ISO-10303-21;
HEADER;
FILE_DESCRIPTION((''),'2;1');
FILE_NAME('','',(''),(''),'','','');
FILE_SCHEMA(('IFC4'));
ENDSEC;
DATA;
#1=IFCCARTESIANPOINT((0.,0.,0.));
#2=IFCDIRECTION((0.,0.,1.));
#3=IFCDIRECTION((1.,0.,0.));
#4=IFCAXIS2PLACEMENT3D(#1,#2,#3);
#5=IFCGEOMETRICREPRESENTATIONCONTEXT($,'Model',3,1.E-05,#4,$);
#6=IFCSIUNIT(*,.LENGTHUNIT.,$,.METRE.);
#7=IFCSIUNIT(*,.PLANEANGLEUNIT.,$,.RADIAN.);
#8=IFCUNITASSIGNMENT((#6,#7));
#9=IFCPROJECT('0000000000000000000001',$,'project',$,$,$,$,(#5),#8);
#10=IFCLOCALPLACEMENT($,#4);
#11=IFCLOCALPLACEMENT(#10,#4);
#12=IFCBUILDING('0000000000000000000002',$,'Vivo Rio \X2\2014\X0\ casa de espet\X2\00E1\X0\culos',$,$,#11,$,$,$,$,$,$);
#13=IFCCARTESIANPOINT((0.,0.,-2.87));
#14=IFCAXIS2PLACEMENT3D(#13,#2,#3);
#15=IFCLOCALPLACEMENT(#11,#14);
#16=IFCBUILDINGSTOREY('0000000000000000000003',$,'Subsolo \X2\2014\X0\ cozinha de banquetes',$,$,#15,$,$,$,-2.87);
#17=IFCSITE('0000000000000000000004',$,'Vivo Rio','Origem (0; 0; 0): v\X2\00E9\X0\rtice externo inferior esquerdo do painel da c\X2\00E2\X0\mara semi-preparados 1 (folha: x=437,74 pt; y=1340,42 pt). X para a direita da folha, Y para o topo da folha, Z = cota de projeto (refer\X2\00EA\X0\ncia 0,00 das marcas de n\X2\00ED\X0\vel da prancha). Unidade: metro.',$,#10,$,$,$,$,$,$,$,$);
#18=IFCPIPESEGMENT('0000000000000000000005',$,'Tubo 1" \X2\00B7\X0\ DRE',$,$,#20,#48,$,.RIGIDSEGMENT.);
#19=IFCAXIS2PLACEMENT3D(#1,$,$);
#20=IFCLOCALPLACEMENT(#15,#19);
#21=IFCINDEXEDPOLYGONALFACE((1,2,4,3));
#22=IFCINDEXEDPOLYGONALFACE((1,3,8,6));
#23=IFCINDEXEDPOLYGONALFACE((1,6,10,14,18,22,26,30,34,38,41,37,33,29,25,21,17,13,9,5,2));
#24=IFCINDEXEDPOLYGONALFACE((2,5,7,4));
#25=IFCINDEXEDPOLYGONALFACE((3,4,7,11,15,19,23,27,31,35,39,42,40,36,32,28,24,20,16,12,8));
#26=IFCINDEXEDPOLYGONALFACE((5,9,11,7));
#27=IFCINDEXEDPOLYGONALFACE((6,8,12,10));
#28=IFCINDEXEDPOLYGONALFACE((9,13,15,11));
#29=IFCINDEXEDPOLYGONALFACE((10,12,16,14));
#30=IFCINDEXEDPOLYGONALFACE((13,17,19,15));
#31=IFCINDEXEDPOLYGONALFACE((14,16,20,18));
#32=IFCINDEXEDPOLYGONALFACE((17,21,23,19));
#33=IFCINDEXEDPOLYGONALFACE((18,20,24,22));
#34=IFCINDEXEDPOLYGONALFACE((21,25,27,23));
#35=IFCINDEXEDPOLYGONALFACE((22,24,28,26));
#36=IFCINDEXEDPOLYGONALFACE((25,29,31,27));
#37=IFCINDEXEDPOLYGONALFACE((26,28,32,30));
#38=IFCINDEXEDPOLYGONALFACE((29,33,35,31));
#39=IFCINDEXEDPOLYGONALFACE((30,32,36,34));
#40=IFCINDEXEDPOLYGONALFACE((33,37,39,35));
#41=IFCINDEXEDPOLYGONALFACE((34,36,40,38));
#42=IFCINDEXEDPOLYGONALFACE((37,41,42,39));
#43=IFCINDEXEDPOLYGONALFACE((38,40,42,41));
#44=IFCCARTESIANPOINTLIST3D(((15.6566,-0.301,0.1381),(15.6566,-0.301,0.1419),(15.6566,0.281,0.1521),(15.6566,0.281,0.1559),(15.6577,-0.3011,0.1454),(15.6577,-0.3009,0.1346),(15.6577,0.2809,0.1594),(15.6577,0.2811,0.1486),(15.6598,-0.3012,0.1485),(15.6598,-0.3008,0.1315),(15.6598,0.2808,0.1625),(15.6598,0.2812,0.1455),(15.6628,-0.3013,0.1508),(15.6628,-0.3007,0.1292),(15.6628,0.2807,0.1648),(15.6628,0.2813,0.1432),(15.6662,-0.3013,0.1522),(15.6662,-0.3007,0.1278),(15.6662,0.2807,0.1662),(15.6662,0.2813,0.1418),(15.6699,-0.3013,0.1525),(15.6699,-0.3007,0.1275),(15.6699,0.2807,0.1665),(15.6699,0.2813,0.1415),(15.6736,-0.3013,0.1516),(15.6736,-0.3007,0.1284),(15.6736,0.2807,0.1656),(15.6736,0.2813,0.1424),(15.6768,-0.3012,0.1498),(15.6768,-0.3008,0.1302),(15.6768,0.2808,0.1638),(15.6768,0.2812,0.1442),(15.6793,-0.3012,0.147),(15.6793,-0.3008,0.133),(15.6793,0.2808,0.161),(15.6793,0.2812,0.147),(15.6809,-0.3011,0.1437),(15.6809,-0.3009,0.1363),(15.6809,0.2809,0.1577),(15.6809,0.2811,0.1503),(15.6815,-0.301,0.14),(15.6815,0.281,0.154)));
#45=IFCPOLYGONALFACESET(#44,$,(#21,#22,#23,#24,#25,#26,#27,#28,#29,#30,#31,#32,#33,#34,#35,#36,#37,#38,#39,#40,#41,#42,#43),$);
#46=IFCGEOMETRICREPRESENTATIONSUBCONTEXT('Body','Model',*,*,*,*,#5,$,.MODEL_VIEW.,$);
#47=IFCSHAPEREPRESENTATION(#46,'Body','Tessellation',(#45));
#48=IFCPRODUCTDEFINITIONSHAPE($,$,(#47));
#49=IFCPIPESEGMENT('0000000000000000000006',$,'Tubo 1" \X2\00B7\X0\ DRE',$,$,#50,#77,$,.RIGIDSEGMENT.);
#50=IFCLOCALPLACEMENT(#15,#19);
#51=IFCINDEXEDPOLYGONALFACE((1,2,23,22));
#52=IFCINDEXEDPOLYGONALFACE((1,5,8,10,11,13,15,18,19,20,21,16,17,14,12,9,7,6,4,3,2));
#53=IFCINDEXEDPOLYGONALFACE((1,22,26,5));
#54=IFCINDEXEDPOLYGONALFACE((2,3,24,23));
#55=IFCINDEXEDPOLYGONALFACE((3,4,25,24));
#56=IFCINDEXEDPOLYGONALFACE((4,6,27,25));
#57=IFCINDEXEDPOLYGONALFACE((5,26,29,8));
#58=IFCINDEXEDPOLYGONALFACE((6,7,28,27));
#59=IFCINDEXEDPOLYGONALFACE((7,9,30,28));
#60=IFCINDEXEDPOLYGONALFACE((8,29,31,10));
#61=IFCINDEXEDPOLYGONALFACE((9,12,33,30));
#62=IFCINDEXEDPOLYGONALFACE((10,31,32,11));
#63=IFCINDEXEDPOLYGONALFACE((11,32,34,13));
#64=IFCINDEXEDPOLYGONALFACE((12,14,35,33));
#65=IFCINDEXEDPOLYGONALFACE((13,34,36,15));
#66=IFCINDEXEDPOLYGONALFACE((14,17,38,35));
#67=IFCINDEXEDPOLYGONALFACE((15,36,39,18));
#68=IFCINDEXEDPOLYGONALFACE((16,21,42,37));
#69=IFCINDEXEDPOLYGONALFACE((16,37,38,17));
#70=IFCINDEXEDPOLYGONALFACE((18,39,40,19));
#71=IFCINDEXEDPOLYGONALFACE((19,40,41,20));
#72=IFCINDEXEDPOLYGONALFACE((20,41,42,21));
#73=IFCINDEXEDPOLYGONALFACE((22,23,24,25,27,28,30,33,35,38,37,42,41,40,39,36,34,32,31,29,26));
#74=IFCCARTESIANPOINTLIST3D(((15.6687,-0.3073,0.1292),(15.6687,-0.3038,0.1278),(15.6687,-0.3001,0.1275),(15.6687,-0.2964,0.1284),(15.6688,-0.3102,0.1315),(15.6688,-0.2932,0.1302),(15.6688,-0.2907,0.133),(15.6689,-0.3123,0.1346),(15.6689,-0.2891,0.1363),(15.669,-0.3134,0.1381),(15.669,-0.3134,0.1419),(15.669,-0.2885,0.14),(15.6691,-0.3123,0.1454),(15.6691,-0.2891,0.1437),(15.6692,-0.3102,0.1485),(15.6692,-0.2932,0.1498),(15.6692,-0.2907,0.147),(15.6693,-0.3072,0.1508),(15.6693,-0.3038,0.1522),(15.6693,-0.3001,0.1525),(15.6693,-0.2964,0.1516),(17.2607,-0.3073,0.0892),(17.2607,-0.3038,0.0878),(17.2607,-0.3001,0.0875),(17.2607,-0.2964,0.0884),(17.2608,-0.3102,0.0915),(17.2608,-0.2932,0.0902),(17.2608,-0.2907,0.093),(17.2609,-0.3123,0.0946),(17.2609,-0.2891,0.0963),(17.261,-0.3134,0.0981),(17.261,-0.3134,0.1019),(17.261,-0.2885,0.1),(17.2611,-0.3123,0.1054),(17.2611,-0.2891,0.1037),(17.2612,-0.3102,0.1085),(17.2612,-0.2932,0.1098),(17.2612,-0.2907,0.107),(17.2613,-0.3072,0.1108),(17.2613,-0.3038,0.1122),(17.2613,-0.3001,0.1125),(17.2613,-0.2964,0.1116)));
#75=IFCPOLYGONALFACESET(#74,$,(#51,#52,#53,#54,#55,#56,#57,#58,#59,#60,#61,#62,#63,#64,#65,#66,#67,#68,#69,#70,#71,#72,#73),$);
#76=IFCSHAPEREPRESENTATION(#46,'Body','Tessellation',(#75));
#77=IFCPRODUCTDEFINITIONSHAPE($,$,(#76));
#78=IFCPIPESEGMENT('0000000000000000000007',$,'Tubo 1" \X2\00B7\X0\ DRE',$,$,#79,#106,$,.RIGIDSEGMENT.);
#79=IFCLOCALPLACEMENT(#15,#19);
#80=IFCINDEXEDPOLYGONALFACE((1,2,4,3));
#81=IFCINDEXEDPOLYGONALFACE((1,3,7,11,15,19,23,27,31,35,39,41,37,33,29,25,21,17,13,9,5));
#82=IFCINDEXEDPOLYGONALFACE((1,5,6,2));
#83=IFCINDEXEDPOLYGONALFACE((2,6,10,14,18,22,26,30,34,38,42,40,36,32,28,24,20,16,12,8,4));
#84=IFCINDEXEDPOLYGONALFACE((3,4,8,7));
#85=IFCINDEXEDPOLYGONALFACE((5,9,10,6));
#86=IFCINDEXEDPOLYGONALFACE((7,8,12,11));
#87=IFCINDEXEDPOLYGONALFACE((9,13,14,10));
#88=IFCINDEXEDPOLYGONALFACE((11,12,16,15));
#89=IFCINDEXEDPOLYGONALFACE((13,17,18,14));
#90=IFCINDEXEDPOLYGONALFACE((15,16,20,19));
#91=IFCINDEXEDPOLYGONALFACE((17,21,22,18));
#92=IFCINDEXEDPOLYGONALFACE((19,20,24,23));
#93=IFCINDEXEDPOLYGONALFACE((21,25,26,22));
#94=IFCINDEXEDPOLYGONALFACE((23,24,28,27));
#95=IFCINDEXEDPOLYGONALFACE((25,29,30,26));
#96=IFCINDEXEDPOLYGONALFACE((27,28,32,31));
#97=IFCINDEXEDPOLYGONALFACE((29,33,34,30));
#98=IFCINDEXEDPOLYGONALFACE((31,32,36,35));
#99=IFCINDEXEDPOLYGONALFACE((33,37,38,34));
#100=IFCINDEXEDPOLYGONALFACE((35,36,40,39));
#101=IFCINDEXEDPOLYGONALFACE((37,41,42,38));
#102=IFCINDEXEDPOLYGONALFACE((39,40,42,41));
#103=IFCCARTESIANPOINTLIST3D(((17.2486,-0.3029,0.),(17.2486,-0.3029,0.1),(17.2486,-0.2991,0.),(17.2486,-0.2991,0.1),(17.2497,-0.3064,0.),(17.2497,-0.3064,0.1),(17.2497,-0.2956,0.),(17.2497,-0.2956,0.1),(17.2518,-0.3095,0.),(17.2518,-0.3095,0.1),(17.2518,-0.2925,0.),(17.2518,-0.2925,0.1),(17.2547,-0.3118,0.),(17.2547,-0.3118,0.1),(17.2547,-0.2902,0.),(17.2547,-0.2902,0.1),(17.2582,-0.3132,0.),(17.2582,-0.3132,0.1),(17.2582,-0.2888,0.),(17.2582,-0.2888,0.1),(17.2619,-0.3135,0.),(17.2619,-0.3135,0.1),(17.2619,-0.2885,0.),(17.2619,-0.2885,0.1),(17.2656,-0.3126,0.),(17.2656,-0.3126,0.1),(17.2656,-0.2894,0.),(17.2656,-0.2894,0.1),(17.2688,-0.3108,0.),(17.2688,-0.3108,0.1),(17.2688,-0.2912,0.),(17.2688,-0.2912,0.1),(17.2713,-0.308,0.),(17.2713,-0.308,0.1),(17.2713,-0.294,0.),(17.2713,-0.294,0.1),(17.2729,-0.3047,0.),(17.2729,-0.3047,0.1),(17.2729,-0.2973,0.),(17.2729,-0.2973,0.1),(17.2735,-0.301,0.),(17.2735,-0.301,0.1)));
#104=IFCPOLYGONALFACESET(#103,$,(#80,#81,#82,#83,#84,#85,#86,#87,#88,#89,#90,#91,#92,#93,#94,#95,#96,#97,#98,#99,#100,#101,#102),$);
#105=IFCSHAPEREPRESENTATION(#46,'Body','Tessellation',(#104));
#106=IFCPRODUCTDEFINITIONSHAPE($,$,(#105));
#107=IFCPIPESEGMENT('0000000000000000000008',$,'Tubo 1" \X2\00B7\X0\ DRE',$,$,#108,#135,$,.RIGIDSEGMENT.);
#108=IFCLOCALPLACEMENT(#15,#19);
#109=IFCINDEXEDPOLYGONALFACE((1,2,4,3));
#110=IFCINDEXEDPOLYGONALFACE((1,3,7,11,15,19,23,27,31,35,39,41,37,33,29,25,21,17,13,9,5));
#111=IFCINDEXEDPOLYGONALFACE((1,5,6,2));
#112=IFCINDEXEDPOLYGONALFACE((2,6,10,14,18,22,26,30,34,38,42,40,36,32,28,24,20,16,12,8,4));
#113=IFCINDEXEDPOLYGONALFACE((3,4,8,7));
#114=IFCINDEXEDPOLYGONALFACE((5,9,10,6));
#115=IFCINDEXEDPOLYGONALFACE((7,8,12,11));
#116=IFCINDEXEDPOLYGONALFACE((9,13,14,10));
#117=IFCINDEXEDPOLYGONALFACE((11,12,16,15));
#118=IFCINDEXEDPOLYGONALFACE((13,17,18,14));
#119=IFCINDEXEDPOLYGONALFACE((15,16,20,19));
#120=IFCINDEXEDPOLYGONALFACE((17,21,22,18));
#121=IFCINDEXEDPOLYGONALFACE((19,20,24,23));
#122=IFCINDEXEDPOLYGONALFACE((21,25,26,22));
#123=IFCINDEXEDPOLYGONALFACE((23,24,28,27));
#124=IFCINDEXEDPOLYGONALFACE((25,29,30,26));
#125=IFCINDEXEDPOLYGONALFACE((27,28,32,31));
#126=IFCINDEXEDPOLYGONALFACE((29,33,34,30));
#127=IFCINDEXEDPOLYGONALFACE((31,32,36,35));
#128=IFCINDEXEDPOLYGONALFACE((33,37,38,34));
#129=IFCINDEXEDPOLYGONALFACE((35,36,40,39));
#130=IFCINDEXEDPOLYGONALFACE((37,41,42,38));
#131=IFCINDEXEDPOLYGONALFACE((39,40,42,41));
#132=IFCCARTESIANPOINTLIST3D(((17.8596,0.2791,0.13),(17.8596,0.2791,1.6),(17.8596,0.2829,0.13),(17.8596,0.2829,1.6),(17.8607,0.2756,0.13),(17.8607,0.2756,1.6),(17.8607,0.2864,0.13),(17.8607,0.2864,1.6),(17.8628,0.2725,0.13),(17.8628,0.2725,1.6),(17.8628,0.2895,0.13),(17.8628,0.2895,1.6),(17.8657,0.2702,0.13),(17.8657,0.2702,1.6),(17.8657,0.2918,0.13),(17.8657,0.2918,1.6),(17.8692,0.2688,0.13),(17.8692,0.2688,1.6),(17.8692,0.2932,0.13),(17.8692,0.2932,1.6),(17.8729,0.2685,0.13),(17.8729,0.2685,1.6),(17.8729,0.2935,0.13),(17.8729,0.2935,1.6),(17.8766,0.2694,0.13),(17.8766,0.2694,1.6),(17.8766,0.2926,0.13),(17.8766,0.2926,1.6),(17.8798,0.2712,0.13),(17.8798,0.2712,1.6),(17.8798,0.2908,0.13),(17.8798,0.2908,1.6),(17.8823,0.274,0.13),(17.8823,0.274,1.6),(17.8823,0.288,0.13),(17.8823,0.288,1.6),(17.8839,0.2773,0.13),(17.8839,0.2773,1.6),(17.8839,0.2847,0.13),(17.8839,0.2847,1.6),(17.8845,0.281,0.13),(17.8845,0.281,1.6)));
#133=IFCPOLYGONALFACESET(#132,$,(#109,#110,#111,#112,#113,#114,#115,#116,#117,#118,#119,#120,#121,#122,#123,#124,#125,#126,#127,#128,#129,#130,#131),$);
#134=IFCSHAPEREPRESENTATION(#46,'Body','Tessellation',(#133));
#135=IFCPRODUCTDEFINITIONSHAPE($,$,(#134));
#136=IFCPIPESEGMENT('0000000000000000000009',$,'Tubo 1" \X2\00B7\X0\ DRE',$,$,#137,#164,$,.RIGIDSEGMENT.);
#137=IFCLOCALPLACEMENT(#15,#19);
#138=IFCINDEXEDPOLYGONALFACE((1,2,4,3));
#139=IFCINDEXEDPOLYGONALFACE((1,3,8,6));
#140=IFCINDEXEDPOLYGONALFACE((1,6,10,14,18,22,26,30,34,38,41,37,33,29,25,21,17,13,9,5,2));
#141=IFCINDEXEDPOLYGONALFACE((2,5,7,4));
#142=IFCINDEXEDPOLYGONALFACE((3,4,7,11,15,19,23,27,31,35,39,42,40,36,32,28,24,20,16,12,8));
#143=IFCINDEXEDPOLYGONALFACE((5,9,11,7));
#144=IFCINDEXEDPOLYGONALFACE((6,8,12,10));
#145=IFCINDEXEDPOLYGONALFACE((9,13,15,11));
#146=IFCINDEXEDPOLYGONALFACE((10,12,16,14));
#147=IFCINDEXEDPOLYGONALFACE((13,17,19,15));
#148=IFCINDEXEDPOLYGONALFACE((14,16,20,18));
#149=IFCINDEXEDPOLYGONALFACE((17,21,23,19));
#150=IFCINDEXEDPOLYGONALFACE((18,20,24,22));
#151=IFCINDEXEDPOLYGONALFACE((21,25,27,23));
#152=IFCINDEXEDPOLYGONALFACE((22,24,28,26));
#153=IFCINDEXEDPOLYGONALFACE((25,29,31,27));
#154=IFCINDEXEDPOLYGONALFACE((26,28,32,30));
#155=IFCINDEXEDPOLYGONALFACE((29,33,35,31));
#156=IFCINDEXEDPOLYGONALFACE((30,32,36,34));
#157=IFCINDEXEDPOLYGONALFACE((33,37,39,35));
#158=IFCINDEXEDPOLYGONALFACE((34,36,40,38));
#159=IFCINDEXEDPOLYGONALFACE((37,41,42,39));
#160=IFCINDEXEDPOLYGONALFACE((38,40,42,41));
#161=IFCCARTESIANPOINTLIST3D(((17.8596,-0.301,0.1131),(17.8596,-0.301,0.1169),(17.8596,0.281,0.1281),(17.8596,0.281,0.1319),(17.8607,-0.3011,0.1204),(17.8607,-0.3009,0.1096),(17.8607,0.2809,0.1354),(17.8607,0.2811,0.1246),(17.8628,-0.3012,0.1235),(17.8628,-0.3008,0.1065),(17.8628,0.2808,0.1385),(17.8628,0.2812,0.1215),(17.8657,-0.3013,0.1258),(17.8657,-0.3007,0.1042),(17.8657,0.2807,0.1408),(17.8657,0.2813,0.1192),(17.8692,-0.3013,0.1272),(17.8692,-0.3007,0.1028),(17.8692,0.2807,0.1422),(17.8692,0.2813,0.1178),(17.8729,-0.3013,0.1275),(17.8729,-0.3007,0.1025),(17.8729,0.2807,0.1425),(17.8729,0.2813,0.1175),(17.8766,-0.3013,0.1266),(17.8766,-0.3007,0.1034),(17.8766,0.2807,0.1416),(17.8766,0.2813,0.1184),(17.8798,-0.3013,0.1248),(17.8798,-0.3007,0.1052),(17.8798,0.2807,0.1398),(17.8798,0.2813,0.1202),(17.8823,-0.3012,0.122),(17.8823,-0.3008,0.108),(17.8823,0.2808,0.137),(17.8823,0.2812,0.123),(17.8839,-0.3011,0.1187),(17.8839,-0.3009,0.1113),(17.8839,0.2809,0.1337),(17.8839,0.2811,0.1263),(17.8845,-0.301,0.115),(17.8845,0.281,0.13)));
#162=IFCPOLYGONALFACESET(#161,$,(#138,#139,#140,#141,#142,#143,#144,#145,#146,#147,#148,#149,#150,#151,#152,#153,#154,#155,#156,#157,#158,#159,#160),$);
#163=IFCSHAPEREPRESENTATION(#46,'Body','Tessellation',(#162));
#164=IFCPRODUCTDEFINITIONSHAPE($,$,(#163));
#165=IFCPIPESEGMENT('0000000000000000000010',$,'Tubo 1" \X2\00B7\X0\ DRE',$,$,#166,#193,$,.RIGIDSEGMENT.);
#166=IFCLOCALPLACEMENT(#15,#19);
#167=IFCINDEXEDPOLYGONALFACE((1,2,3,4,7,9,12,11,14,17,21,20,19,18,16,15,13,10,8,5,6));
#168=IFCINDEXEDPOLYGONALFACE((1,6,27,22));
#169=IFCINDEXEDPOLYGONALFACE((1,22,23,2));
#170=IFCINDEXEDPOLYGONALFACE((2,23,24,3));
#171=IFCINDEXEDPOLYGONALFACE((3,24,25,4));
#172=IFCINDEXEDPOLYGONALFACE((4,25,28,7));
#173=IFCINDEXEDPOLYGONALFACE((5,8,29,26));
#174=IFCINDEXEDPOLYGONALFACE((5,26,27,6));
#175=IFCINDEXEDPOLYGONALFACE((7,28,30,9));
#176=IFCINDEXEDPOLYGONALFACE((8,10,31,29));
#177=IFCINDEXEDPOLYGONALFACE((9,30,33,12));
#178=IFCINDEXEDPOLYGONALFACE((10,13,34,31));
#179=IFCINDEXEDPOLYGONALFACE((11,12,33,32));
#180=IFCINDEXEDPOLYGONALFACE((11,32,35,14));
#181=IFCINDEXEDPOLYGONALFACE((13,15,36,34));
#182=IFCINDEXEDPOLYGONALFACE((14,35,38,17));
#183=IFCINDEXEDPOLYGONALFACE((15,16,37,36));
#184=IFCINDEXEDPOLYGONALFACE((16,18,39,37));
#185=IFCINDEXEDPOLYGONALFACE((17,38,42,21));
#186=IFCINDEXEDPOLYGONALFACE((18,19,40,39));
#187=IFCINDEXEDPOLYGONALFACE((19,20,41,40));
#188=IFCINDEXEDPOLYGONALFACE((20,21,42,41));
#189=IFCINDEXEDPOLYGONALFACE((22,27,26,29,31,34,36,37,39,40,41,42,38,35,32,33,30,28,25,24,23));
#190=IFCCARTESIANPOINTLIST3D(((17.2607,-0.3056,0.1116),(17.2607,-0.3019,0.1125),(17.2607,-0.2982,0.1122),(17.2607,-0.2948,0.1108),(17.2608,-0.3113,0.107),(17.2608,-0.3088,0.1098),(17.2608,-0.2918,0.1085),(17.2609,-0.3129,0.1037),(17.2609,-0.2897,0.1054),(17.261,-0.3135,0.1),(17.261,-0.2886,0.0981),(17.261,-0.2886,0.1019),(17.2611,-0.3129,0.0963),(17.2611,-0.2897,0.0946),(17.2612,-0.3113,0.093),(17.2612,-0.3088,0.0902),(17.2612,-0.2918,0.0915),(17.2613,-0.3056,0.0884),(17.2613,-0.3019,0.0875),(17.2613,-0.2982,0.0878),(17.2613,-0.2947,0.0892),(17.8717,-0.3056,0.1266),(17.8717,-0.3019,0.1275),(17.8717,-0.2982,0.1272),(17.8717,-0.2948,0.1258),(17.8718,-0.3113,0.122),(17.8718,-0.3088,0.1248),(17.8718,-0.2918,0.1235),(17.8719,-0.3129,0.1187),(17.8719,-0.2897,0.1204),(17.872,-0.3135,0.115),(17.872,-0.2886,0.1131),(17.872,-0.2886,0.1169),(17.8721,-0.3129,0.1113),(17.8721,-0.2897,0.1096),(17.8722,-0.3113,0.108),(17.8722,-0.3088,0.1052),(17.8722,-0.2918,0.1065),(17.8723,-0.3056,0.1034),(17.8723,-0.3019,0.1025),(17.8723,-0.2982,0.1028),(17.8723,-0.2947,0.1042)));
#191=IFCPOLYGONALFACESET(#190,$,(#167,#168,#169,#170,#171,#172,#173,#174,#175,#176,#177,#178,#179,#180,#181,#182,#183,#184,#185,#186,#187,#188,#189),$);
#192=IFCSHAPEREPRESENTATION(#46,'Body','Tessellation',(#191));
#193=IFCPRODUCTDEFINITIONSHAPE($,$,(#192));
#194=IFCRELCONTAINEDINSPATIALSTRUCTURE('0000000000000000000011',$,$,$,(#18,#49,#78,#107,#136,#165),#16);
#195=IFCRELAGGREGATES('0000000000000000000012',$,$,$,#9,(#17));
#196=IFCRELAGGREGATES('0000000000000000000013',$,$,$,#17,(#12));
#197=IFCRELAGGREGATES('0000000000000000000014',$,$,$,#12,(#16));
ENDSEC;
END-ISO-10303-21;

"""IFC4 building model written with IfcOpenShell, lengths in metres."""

from ifc_helpers import new_model, si_unit, frame, origin_with_axes, origin_2d, place, context, subcontext, project, spatial, circle, extrude, element, save


model = new_model("IFC4")

# Units and contexts
model_context = context("Model", 3, precision=1e-05, world=origin_with_axes())
body_context = subcontext(model_context, "Body", "Model", "MODEL_VIEW")
ifc_project = project(units=[si_unit("LENGTHUNIT", "METRE"), si_unit("PLANEANGLEUNIT", "RADIAN")], contexts=[model_context])

# Site, building, storey
site_placement = place(None, origin_with_axes())
site = spatial("IfcSite", under=ifc_project, at=site_placement, Name="Vivo Rio", Description="Origem (0; 0; 0): vértice externo inferior esquerdo do painel da câmara semi-preparados 1 (folha: x=437,74 pt; y=1340,42 pt). X para a direita da folha, Y para o topo da folha, Z = cota de projeto (referência 0,00 das marcas de nível da prancha). Unidade: metro.")
building_placement = place(site_placement, origin_with_axes())
building = spatial("IfcBuilding", under=site, at=building_placement, Name="Vivo Rio — casa de espetáculos")
storey_placement = place(building_placement, frame((0.0, 0.0, -2.87), z_axis=(0.0, 0.0, 1.0), x_axis=(1.0, 0.0, 0.0)))
storey = spatial("IfcBuildingStorey", under=building, at=storey_placement, Name="Subsolo — cozinha de banquetes", Elevation=-2.87)

# Pipe segments
pipe_segment_1_placement = place(storey_placement, origin_with_axes())
element("IfcPipeSegment", 1, at=pipe_segment_1_placement, inside=storey, Name="Tubo 1\" · DRE", PredefinedType="RIGIDSEGMENT", context=body_context, shape_type="SweptSolid", body=[
    extrude(circle(Radius=0.0125, at=origin_2d()), frame((15.669, 0.281, 0.154), z_axis=(0.0, -0.999711, -0.024048), x_axis=(1.0, 0.0, 0.0)), (0.0, 0.0, 1.0), 0.5822),
])
pipe_segment_2_placement = place(storey_placement, origin_with_axes())
element("IfcPipeSegment", 2, at=pipe_segment_2_placement, inside=storey, Name="Tubo 1\" · DRE", PredefinedType="RIGIDSEGMENT", context=body_context, shape_type="SweptSolid", body=[
    extrude(circle(Radius=0.0125, at=origin_2d()), frame((15.669, -0.301, 0.14), z_axis=(0.999685, 0.0, -0.025118), x_axis=(0.0, 1.0, 0.0)), (0.0, 0.0, 1.0), 1.5925),
])
pipe_segment_3_placement = place(storey_placement, origin_with_axes())
element("IfcPipeSegment", 3, at=pipe_segment_3_placement, inside=storey, Name="Tubo 1\" · DRE", PredefinedType="RIGIDSEGMENT", context=body_context, shape_type="SweptSolid", body=[
    extrude(circle(Radius=0.0125, at=origin_2d()), frame((17.261, -0.301, 0.1), z_axis=(0.0, 0.0, -1.0), x_axis=(1.0, 0.0, 0.0)), (0.0, 0.0, 1.0), 0.1),
])
pipe_segment_4_placement = place(storey_placement, origin_with_axes())
element("IfcPipeSegment", 4, at=pipe_segment_4_placement, inside=storey, Name="Tubo 1\" · DRE", PredefinedType="RIGIDSEGMENT", context=body_context, shape_type="SweptSolid", body=[
    extrude(circle(Radius=0.0125, at=origin_2d()), frame((17.872, 0.281, 1.6), z_axis=(0.0, 0.0, -1.0), x_axis=(1.0, 0.0, 0.0)), (0.0, 0.0, 1.0), 1.47),
])
pipe_segment_5_placement = place(storey_placement, origin_with_axes())
element("IfcPipeSegment", 5, at=pipe_segment_5_placement, inside=storey, Name="Tubo 1\" · DRE", PredefinedType="RIGIDSEGMENT", context=body_context, shape_type="SweptSolid", body=[
    extrude(circle(Radius=0.0125, at=origin_2d()), frame((17.872, 0.281, 0.13), z_axis=(0.0, -0.999668, -0.025765), x_axis=(1.0, 0.0, 0.0)), (0.0, 0.0, 1.0), 0.5822),
])
pipe_segment_6_placement = place(storey_placement, origin_with_axes())
element("IfcPipeSegment", 6, at=pipe_segment_6_placement, inside=storey, Name="Tubo 1\" · DRE", PredefinedType="RIGIDSEGMENT", context=body_context, shape_type="SweptSolid", body=[
    extrude(circle(Radius=0.0125, at=origin_2d()), frame((17.872, -0.301, 0.115), z_axis=(-0.999699, 0.0, -0.024543), x_axis=(0.0, -1.0, 0.0)), (0.0, 0.0, 1.0), 0.6112),
])

save(model, "model.ifc")
